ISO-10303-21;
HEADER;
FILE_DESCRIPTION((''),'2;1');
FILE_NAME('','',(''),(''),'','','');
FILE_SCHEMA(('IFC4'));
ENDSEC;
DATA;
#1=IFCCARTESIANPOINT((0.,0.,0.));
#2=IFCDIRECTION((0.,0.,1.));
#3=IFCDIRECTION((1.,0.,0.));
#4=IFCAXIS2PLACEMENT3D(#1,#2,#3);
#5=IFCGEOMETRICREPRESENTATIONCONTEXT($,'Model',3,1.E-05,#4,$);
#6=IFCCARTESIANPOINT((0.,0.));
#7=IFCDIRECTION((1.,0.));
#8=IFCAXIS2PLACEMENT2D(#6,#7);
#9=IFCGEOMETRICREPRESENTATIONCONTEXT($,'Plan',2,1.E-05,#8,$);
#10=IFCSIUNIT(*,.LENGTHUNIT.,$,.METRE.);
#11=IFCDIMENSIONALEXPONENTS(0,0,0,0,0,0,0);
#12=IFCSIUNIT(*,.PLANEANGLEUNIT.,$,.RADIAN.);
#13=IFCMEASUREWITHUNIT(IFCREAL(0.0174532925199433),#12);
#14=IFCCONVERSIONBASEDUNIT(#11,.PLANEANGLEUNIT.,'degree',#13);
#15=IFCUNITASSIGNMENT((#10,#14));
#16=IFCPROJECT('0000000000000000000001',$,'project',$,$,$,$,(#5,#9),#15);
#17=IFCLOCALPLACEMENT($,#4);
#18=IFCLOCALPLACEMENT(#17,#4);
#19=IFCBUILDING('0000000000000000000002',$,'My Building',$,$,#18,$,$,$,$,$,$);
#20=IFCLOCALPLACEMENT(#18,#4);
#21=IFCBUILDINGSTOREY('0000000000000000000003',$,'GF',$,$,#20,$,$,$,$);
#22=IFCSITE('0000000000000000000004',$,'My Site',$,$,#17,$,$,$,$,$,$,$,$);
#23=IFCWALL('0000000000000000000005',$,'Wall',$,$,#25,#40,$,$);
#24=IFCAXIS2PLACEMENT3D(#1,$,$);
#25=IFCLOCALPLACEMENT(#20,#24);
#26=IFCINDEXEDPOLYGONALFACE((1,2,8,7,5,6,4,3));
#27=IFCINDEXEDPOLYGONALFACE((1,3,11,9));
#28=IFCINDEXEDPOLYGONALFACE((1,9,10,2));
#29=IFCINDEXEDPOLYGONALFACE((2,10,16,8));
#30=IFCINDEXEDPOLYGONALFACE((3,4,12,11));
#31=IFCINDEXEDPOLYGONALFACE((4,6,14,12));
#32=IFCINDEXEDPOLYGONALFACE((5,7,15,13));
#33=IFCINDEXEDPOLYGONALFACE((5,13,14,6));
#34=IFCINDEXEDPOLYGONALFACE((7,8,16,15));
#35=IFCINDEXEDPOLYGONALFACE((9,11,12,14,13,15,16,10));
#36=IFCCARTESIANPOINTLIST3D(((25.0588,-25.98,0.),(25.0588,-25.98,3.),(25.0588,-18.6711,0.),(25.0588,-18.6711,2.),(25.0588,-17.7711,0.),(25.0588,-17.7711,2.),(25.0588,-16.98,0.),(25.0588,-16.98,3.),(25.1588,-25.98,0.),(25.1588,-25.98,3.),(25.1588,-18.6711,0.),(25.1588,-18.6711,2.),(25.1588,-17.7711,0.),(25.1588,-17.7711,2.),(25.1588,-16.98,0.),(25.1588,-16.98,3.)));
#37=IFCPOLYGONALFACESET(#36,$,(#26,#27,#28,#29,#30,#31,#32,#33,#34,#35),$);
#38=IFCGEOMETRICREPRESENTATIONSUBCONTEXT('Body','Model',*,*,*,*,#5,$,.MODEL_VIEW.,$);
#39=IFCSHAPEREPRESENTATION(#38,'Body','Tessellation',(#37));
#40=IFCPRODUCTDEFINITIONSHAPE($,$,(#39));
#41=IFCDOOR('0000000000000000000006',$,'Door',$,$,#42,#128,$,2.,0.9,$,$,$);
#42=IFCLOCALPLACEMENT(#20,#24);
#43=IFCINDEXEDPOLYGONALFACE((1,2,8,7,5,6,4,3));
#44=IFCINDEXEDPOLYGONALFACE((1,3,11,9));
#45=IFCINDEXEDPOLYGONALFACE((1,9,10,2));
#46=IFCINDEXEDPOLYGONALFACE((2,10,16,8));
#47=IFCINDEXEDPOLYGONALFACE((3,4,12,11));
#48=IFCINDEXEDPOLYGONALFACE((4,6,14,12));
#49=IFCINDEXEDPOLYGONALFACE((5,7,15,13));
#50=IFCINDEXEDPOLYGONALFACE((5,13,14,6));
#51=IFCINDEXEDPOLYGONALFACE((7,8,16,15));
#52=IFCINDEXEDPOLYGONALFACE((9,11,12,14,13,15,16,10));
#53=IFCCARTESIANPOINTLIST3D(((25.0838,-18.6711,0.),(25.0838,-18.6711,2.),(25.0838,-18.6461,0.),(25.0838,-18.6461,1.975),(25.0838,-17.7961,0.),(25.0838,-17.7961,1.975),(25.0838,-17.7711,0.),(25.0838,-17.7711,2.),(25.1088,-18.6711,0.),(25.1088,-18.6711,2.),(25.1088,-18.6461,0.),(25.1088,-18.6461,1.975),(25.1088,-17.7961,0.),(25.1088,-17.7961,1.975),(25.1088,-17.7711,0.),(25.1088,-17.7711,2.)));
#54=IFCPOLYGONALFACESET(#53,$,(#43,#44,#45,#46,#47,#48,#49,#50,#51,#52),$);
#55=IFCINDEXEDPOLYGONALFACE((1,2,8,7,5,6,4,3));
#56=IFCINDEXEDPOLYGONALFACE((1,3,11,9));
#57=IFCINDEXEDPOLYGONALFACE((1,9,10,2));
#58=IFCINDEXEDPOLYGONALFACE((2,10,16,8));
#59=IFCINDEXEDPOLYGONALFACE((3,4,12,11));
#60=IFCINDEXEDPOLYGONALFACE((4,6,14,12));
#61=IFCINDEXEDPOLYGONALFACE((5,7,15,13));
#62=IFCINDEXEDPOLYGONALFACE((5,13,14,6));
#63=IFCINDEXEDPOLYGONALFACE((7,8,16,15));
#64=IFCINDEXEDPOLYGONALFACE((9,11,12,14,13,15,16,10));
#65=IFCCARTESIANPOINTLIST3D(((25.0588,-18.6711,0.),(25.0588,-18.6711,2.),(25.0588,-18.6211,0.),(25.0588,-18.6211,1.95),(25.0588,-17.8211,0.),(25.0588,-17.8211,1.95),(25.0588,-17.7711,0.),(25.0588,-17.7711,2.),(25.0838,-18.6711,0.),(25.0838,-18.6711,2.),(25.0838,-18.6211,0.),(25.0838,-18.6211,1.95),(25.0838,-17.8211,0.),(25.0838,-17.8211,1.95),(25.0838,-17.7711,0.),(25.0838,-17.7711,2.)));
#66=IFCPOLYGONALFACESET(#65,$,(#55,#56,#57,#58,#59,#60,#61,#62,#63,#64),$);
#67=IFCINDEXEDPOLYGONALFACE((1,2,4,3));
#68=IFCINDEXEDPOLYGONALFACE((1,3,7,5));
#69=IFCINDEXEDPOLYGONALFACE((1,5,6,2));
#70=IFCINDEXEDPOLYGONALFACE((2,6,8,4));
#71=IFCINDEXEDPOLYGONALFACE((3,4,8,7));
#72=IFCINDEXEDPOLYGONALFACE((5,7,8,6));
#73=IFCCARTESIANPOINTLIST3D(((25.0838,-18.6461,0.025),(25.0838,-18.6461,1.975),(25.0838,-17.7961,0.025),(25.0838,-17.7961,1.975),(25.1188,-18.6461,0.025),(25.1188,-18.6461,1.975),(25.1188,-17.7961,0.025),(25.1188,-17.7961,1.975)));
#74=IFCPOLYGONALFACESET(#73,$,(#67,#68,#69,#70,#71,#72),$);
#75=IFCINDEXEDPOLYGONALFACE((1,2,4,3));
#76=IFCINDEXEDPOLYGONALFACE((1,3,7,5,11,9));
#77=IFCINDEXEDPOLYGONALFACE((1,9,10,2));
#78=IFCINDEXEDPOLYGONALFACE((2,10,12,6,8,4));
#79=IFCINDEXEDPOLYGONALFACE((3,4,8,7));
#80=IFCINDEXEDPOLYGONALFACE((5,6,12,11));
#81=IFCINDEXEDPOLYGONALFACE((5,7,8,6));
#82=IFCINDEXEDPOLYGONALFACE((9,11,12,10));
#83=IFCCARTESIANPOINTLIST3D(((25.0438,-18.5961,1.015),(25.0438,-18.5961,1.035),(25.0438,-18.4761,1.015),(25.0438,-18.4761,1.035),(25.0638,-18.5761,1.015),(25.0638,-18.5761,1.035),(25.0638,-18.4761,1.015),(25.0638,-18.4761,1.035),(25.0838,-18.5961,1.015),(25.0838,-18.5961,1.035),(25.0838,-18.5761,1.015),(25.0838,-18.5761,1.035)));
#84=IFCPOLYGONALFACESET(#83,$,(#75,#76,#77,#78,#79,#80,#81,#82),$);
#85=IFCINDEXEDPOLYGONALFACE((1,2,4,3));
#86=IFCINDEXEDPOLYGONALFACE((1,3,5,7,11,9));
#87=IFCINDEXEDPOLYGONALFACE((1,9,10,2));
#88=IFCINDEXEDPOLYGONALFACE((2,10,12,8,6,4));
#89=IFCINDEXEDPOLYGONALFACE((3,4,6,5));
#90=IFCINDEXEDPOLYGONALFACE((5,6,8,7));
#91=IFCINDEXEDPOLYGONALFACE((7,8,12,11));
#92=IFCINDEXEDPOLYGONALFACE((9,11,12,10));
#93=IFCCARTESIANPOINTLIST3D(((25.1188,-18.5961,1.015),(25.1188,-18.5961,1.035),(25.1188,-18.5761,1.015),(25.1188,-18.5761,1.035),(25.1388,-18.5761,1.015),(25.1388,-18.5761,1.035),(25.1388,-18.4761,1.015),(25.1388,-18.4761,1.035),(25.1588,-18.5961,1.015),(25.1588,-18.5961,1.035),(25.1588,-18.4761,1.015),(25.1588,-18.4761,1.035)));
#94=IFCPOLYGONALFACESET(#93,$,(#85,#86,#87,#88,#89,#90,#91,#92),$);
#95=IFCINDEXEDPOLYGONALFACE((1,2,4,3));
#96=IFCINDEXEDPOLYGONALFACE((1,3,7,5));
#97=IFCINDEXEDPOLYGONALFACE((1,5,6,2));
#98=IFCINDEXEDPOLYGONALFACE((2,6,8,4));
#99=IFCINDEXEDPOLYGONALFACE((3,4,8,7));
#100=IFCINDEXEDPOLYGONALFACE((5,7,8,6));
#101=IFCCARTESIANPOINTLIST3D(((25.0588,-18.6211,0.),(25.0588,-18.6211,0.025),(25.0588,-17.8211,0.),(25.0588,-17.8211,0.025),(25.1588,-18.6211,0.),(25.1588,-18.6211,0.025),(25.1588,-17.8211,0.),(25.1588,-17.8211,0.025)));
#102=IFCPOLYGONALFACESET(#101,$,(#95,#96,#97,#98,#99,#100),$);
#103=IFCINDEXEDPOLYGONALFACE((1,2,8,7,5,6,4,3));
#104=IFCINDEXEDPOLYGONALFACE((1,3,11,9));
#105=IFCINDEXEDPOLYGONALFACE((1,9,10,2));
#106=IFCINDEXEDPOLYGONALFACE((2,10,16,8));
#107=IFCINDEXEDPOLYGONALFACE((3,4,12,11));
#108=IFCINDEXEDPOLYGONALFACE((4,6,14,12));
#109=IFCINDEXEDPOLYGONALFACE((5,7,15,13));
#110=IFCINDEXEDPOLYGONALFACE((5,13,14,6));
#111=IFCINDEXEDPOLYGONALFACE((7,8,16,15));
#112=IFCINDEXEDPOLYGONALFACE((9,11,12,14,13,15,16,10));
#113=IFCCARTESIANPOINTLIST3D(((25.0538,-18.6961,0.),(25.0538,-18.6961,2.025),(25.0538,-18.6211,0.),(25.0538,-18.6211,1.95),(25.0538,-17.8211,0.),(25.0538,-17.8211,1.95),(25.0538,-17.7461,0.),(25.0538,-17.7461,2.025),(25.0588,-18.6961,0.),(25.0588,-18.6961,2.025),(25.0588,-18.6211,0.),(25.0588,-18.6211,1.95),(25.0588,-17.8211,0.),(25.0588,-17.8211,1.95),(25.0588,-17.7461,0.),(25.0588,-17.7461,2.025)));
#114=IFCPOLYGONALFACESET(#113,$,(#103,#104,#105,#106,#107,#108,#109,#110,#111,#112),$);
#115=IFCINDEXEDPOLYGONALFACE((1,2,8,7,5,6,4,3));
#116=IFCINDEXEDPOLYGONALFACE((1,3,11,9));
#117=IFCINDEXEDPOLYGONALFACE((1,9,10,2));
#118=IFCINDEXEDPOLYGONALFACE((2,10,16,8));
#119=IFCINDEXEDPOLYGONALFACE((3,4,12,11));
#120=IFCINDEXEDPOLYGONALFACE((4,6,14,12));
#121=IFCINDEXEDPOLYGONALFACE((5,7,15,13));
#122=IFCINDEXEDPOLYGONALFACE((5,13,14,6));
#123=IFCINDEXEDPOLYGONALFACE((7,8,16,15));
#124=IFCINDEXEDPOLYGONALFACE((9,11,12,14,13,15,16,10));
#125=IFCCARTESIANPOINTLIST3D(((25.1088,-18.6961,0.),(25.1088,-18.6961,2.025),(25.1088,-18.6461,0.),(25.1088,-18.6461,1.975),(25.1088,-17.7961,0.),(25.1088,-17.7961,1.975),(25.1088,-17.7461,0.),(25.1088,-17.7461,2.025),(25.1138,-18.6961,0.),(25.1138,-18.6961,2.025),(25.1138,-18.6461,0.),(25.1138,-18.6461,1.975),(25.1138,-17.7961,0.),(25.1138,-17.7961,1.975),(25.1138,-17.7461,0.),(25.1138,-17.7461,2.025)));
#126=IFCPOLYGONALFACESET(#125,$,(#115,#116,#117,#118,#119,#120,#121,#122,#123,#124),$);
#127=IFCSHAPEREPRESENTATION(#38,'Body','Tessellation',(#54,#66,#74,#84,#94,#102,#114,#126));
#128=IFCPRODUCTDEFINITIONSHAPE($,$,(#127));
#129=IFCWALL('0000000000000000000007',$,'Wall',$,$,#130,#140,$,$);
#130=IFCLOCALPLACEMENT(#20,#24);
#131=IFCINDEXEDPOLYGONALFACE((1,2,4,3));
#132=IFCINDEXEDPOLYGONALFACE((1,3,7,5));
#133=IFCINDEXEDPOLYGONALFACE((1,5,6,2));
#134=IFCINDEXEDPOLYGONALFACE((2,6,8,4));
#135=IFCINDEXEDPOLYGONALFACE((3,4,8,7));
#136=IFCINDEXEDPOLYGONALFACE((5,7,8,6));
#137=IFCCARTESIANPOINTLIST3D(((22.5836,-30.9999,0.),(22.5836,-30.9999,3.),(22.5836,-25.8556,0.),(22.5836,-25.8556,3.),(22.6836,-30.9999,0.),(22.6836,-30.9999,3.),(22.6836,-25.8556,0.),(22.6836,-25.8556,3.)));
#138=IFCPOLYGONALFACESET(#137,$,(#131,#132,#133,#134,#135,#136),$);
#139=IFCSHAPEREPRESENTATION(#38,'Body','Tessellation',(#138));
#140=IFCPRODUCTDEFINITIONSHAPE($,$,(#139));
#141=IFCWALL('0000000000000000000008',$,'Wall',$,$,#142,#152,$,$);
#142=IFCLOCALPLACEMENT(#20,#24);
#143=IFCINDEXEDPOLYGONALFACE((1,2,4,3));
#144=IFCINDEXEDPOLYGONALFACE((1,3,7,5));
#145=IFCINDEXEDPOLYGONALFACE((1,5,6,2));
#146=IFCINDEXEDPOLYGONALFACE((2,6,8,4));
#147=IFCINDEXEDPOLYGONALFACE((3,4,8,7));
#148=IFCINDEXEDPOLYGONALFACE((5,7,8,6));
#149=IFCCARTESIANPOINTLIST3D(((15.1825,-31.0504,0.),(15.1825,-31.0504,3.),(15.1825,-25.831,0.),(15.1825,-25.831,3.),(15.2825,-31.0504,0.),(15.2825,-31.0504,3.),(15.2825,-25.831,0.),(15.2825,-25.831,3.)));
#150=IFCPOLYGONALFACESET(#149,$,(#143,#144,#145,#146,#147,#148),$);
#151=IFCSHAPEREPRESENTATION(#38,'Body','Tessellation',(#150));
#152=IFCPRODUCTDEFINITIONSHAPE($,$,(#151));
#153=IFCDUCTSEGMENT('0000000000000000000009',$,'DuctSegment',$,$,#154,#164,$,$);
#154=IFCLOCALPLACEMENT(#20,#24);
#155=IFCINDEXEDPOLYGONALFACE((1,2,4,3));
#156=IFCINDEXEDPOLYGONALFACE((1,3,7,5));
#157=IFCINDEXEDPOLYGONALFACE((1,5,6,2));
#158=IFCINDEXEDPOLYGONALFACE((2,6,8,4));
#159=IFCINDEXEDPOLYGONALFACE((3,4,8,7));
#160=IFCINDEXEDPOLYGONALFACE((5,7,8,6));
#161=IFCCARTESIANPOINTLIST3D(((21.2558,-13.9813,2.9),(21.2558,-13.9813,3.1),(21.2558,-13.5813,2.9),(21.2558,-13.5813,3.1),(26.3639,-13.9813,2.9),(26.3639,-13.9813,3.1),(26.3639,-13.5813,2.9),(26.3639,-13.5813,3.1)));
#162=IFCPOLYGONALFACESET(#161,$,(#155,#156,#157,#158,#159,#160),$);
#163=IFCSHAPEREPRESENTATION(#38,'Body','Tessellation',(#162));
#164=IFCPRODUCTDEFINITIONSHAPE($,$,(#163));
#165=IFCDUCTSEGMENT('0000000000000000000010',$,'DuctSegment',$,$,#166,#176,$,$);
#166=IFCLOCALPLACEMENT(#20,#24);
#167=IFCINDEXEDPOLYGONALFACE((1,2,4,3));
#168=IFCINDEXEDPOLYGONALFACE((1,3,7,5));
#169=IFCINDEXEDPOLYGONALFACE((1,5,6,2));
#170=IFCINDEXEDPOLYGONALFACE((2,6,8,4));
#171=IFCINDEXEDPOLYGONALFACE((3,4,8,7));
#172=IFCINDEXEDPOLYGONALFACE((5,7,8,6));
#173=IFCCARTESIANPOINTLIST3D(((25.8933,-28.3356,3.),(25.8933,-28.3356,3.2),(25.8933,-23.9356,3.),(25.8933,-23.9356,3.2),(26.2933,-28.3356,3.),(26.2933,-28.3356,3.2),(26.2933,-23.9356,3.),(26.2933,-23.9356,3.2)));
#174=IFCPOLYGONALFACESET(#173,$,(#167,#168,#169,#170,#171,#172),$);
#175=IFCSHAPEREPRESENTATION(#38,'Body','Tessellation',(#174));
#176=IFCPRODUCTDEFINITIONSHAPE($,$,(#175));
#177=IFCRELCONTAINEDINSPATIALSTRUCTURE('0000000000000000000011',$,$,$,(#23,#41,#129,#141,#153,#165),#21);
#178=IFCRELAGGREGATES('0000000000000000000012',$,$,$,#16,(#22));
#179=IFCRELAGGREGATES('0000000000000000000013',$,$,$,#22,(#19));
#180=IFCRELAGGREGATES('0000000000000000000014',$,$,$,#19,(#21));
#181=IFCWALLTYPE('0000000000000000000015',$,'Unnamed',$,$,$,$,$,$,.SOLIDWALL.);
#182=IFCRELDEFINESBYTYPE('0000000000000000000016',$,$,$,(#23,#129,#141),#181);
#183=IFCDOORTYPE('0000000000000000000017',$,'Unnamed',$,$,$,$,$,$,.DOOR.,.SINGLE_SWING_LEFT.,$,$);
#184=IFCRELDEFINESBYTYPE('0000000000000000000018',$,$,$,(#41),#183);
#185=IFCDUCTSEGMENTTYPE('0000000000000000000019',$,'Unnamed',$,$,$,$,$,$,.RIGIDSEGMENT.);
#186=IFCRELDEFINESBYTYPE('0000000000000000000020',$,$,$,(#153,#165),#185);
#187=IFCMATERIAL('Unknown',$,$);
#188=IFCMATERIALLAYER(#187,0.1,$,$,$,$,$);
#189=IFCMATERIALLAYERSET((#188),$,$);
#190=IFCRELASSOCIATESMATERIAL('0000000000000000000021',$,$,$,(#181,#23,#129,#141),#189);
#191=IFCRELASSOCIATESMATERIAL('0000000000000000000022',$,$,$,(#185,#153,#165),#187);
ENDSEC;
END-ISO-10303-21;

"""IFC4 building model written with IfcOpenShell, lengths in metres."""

from ifc_helpers import new_model, entity, si_unit, converted_unit, frame, origin_with_axes, origin_2d_with_axis, place, context, subcontext, project, spatial, line, indexed_curve, rectangle, outline, extrude, shape, source, transform, mapped, material, layer, layer_set, layer_usage, material_profile, profile_set, profile_usage, type_object, type_shapes, element, fill, save


model = new_model("IFC4")

# Units and contexts
model_context = context("Model", 3, precision=1e-05, world=origin_with_axes())
plan_context = context("Plan", 2, precision=1e-05, world=origin_2d_with_axis())
body_context_1 = subcontext(model_context, "Body", "Model", "MODEL_VIEW")
body_context_2 = subcontext(plan_context, "Body", "Plan", "PLAN_VIEW")
ifc_project = project(units=[si_unit("LENGTHUNIT", "METRE"), converted_unit("PLANEANGLEUNIT", "degree", entity("IfcReal", 0.0174532925199433), si_unit("PLANEANGLEUNIT", "RADIAN"), dimensions=[0, 0, 0, 0, 0, 0, 0])], contexts=[model_context, plan_context])

# Site, building, storey
site_placement = place(None, origin_with_axes())
site = spatial("IfcSite", under=ifc_project, at=site_placement, Name="My Site")
building_placement = place(site_placement, origin_with_axes())
building = spatial("IfcBuilding", under=site, at=building_placement, Name="My Building")
storey_placement = place(building_placement, origin_with_axes())
storey = spatial("IfcBuildingStorey", under=building, at=storey_placement, Name="GF")

# Shared definitions
ifc_material = material(Name="Unknown")
ifc_layer = layer(ifc_material, 0.1)
ifc_layer_set = layer_set([ifc_layer])
wall_type = type_object("IfcWallType", Name="Unnamed", PredefinedType="SOLIDWALL", material=ifc_layer_set)

# Shared definitions
shared_shape_1 = source(origin_with_axes(), body_context_1, "Body", "SweptSolid", [
    extrude(outline(indexed_curve([(0.0, 0.0), (0.9, 0.0), (0.9, 2.0), (0.0, 2.0)], segments=[line(1, 2, 3, 4, 1)])), frame((0.0, -0.6, 0.0), z_axis=(0.0, -1.0, 0.0), x_axis=(1.0, 0.0, 0.0)), (0.0, 0.0, -1.0), 1.2),
])
door_type = type_object("IfcDoorType", Name="Unnamed", OperationType="SINGLE_SWING_LEFT", PredefinedType="DOOR")
shared_shape_2 = source(origin_with_axes(), body_context_1, "Body", "SweptSolid", [
    extrude(outline(indexed_curve([(0.0, 0.0), (0.0, 2.0), (0.9, 2.0), (0.9, 0.0), (0.875, 0.0), (0.875, 1.975), (0.025, 1.975), (0.025, 0.0)], segments=[line(1, 2, 3, 4, 5, 6, 7, 8, 1)])), frame((0.0, 0.025, 0.0), z_axis=(0.0, -1.0, 0.0), x_axis=(1.0, 0.0, 0.0)), (0.0, 0.0, -1.0), 0.025),
    extrude(outline(indexed_curve([(0.0, 0.0), (0.0, 2.0), (0.9, 2.0), (0.9, 0.0), (0.85, 0.0), (0.85, 1.95), (0.05, 1.95), (0.05, 0.0)], segments=[line(1, 2, 3, 4, 5, 6, 7, 8, 1)])), frame((0.0, 0.0, 0.0), z_axis=(0.0, -1.0, 0.0), x_axis=(1.0, 0.0, 0.0)), (0.0, 0.0, -1.0), 0.025),
    extrude(outline(indexed_curve([(0.0, 0.0), (0.85, 0.0), (0.85, 0.035), (0.0, 0.035)], segments=[line(1, 2, 3, 4, 1)])), frame((0.025, 0.025, 0.025), z_axis=(0.0, 0.0, 1.0), x_axis=(1.0, 0.0, 0.0)), (0.0, 0.0, 1.0), 1.95),
    extrude(outline(indexed_curve([(0.0, 0.0), (0.0, -0.04), (-0.12, -0.04), (-0.12, -0.02), (-0.02, -0.02), (-0.02, 0.0)], segments=[line(1, 2, 3, 4, 5, 6, 1)])), frame((0.825, 0.025, 1.015), z_axis=(0.0, 0.0, 1.0), x_axis=(1.0, 0.0, 0.0)), (0.0, 0.0, 1.0), 0.02),
    extrude(outline(indexed_curve([(0.0, 0.0), (0.0, 0.04), (-0.12, 0.04), (-0.12, 0.02), (-0.02, 0.02), (-0.02, 0.0)], segments=[line(1, 2, 3, 4, 5, 6, 1)])), frame((0.825, 0.06, 1.015), z_axis=(0.0, 0.0, 1.0), x_axis=(1.0, 0.0, 0.0)), (0.0, 0.0, 1.0), 0.02),
    extrude(outline(indexed_curve([(0.0, 0.0), (0.8, 0.0), (0.8, 0.1), (0.0, 0.1)], segments=[line(1, 2, 3, 4, 1)])), frame((0.05, 0.0, 0.0), z_axis=(0.0, 0.0, 1.0), x_axis=(1.0, 0.0, 0.0)), (0.0, 0.0, 1.0), 0.025),
    extrude(outline(indexed_curve([(0.0, 0.0), (0.0, 2.025), (0.95, 2.025), (0.95, 0.0), (0.875, 0.0), (0.875, 1.95), (0.075, 1.95), (0.075, 0.0)], segments=[line(1, 2, 3, 4, 5, 6, 7, 8, 1)])), frame((-0.025, -0.005, 0.0), z_axis=(0.0, -1.0, 0.0), x_axis=(1.0, 0.0, 0.0)), (0.0, 0.0, -1.0), 0.005),
    extrude(outline(indexed_curve([(0.0, 0.0), (0.0, 2.025), (0.95, 2.025), (0.95, 0.0), (0.9, 0.0), (0.9, 1.975), (0.05, 1.975), (0.05, 0.0)], segments=[line(1, 2, 3, 4, 5, 6, 7, 8, 1)])), frame((-0.025, 0.05, 0.0), z_axis=(0.0, -1.0, 0.0), x_axis=(1.0, 0.0, 0.0)), (0.0, 0.0, -1.0), 0.005),
])
shared_shape_3 = source(origin_with_axes(), body_context_2, "Body", "Curve2D", [
    entity("IfcIndexedPolyCurve", entity("IfcCartesianPointList2D", [[0.0, 0.0], [0.0, 0.05], [0.025, 0.05], [0.025, 0.025], [0.05, 0.025], [0.05, 0.0]]), [entity("IfcLineIndex", [1, 2, 3, 4, 5, 6, 1])]),
    entity("IfcIndexedPolyCurve", entity("IfcCartesianPointList2D", [[0.9, 0.0], [0.9, 0.05], [0.875, 0.05], [0.875, 0.025], [0.85, 0.025], [0.85, 0.0]]), [entity("IfcLineIndex", [1, 2, 3, 4, 5, 6, 1])]),
    entity("IfcTrimmedCurve", entity("IfcEllipse", entity("IfcAxis2Placement2D", entity("IfcCartesianPoint", [0.06, 0.05]), entity("IfcDirection", [1.0, 0.0])), 0.815, 0.85), [entity("IfcCartesianPoint", [0.875, 0.05])], [entity("IfcCartesianPoint", [0.06, 0.9])], True, "CARTESIAN"),
    entity("IfcIndexedPolyCurve", entity("IfcCartesianPointList2D", [[0.025, 0.05], [0.06, 0.05], [0.06, 0.9], [0.025, 0.9]]), [entity("IfcLineIndex", [1, 2, 3, 4, 1])]),
])
type_shapes(door_type, [shared_shape_2, shared_shape_3])

# Wall, opening, door
ifc_layer_usage_1 = layer_usage(ifc_layer_set, "AXIS2", "POSITIVE", 0.0)
wall_1_placement = place(storey_placement, frame((25.0588, -16.98, 0.0), z_axis=(0.0, 0.0, 1.0), x_axis=(0.0, -1.0, 0.0)))
wall_1 = element("IfcWall", 1, at=wall_1_placement, inside=storey, type_object=wall_type, material=ifc_layer_usage_1, Name="Wall", context=body_context_1, shape_type="SweptSolid", body=[
    extrude(outline(indexed_curve([(0.0, 0.0), (0.0, 0.1), (9.0, 0.1), (9.0, 0.0)], segments=[line(1, 2, 3, 4, 1)])), origin_with_axes(), (0.0, 0.0, 1.0), 3.0),
])
opening_1_placement = place(wall_1_placement, frame((0.7911, 0.0, 0.0), z_axis=(0.0, 0.0, 1.0), x_axis=(1.0, 0.0, 0.0)))
opening_1 = element("IfcOpeningElement", 2, at=opening_1_placement, cuts=wall_1, PredefinedType="OPENING", context=body_context_1, shape_type="MappedRepresentation", body=[
    mapped(shared_shape_1, transform((0.0, 0.0, 0.0), x_axis=(1.0, 0.0, 0.0), y_axis=(0.0, 1.0, 0.0), z_axis=(0.0, 0.0, 1.0), scale=1.0)),
])
door_1_placement = place(opening_1_placement, frame((0.0, 0.0, 0.0), z_axis=(0.0, 0.0, 1.0), x_axis=(1.0, 0.0, 0.0)))
door_1 = element("IfcDoor", 3, at=door_1_placement, inside=storey, type_object=door_type, Name="Door", OverallHeight=2.0, OverallWidth=0.9, shapes=[
    shape(body_context_1, "Body", "MappedRepresentation", [mapped(shared_shape_2, transform((0.0, 0.0, 0.0), x_axis=(1.0, 0.0, 0.0), y_axis=(0.0, 1.0, 0.0), z_axis=(0.0, 0.0, 1.0), scale=1.0))]),
    shape(body_context_2, "Body", "MappedRepresentation", [mapped(shared_shape_3, transform((0.0, 0.0, 0.0), x_axis=(1.0, 0.0, 0.0), y_axis=(0.0, 1.0, 0.0), z_axis=(0.0, 0.0, 1.0), scale=1.0))]),
])
fill(opening_1, door_1)

# Walls
ifc_layer_usage_2 = layer_usage(ifc_layer_set, "AXIS2", "POSITIVE", 0.0)
wall_2_placement = place(storey_placement, frame((22.5836, -25.8556, 0.0), z_axis=(0.0, 0.0, 1.0), x_axis=(0.0, -1.0, 0.0)))
element("IfcWall", 4, at=wall_2_placement, inside=storey, type_object=wall_type, material=ifc_layer_usage_2, Name="Wall", context=body_context_1, shape_type="SweptSolid", body=[
    extrude(outline(indexed_curve([(0.0, 0.0), (0.0, 0.1), (5.1443, 0.1), (5.1443, 0.0)], segments=[line(1, 2, 3, 4, 1)])), origin_with_axes(), (0.0, 0.0, 1.0), 3.0),
])
ifc_layer_usage_3 = layer_usage(ifc_layer_set, "AXIS2", "POSITIVE", 0.0)
wall_3_placement = place(storey_placement, frame((15.1825, -25.831, 0.0), z_axis=(0.0, 0.0, 1.0), x_axis=(0.0, -1.0, 0.0)))
element("IfcWall", 5, at=wall_3_placement, inside=storey, type_object=wall_type, material=ifc_layer_usage_3, Name="Wall", context=body_context_1, shape_type="SweptSolid", body=[
    extrude(outline(indexed_curve([(0.0, 0.0), (0.0, 0.1), (5.2194, 0.1), (5.2194, 0.0)], segments=[line(1, 2, 3, 4, 1)])), origin_with_axes(), (0.0, 0.0, 1.0), 3.0),
])

# Duct segments
ifc_material_profile_1 = material_profile(ifc_material, rectangle(XDim=0.4, YDim=0.2))
ifc_profile_set_1 = profile_set([ifc_material_profile_1])
ifc_profile_usage_1 = profile_usage(ifc_profile_set_1, cardinal=5)
duct_segment_type = type_object("IfcDuctSegmentType", Name="Unnamed", PredefinedType="RIGIDSEGMENT", material=ifc_profile_set_1)
duct_segment_1_placement = place(storey_placement, frame((21.2558, -13.7813, 3.0), z_axis=(1.0, 0.0, 0.0), x_axis=(0.0, 1.0, 0.0)))
element("IfcDuctSegment", 6, at=duct_segment_1_placement, inside=storey, type_object=duct_segment_type, material=ifc_profile_usage_1, Name="DuctSegment", context=body_context_1, shape_type="SweptSolid", body=[
    extrude(rectangle(XDim=0.4, YDim=0.2), origin_with_axes(), (0.0, 0.0, 1.0), 5.1081),
])
ifc_profile_usage_2 = profile_usage(ifc_profile_set_1, cardinal=5)
duct_segment_2_placement = place(storey_placement, frame((26.0933, -23.9356, 3.1), z_axis=(0.0, -1.0, 0.000001), x_axis=(1.0, 0.0, 0.0)))
element("IfcDuctSegment", 7, at=duct_segment_2_placement, inside=storey, type_object=duct_segment_type, material=ifc_profile_usage_2, Name="DuctSegment", context=body_context_1, shape_type="SweptSolid", body=[
    extrude(rectangle(XDim=0.4, YDim=0.2), origin_with_axes(), (0.0, 0.0, 1.0), 4.4),
])

save(model, "model.ifc")
